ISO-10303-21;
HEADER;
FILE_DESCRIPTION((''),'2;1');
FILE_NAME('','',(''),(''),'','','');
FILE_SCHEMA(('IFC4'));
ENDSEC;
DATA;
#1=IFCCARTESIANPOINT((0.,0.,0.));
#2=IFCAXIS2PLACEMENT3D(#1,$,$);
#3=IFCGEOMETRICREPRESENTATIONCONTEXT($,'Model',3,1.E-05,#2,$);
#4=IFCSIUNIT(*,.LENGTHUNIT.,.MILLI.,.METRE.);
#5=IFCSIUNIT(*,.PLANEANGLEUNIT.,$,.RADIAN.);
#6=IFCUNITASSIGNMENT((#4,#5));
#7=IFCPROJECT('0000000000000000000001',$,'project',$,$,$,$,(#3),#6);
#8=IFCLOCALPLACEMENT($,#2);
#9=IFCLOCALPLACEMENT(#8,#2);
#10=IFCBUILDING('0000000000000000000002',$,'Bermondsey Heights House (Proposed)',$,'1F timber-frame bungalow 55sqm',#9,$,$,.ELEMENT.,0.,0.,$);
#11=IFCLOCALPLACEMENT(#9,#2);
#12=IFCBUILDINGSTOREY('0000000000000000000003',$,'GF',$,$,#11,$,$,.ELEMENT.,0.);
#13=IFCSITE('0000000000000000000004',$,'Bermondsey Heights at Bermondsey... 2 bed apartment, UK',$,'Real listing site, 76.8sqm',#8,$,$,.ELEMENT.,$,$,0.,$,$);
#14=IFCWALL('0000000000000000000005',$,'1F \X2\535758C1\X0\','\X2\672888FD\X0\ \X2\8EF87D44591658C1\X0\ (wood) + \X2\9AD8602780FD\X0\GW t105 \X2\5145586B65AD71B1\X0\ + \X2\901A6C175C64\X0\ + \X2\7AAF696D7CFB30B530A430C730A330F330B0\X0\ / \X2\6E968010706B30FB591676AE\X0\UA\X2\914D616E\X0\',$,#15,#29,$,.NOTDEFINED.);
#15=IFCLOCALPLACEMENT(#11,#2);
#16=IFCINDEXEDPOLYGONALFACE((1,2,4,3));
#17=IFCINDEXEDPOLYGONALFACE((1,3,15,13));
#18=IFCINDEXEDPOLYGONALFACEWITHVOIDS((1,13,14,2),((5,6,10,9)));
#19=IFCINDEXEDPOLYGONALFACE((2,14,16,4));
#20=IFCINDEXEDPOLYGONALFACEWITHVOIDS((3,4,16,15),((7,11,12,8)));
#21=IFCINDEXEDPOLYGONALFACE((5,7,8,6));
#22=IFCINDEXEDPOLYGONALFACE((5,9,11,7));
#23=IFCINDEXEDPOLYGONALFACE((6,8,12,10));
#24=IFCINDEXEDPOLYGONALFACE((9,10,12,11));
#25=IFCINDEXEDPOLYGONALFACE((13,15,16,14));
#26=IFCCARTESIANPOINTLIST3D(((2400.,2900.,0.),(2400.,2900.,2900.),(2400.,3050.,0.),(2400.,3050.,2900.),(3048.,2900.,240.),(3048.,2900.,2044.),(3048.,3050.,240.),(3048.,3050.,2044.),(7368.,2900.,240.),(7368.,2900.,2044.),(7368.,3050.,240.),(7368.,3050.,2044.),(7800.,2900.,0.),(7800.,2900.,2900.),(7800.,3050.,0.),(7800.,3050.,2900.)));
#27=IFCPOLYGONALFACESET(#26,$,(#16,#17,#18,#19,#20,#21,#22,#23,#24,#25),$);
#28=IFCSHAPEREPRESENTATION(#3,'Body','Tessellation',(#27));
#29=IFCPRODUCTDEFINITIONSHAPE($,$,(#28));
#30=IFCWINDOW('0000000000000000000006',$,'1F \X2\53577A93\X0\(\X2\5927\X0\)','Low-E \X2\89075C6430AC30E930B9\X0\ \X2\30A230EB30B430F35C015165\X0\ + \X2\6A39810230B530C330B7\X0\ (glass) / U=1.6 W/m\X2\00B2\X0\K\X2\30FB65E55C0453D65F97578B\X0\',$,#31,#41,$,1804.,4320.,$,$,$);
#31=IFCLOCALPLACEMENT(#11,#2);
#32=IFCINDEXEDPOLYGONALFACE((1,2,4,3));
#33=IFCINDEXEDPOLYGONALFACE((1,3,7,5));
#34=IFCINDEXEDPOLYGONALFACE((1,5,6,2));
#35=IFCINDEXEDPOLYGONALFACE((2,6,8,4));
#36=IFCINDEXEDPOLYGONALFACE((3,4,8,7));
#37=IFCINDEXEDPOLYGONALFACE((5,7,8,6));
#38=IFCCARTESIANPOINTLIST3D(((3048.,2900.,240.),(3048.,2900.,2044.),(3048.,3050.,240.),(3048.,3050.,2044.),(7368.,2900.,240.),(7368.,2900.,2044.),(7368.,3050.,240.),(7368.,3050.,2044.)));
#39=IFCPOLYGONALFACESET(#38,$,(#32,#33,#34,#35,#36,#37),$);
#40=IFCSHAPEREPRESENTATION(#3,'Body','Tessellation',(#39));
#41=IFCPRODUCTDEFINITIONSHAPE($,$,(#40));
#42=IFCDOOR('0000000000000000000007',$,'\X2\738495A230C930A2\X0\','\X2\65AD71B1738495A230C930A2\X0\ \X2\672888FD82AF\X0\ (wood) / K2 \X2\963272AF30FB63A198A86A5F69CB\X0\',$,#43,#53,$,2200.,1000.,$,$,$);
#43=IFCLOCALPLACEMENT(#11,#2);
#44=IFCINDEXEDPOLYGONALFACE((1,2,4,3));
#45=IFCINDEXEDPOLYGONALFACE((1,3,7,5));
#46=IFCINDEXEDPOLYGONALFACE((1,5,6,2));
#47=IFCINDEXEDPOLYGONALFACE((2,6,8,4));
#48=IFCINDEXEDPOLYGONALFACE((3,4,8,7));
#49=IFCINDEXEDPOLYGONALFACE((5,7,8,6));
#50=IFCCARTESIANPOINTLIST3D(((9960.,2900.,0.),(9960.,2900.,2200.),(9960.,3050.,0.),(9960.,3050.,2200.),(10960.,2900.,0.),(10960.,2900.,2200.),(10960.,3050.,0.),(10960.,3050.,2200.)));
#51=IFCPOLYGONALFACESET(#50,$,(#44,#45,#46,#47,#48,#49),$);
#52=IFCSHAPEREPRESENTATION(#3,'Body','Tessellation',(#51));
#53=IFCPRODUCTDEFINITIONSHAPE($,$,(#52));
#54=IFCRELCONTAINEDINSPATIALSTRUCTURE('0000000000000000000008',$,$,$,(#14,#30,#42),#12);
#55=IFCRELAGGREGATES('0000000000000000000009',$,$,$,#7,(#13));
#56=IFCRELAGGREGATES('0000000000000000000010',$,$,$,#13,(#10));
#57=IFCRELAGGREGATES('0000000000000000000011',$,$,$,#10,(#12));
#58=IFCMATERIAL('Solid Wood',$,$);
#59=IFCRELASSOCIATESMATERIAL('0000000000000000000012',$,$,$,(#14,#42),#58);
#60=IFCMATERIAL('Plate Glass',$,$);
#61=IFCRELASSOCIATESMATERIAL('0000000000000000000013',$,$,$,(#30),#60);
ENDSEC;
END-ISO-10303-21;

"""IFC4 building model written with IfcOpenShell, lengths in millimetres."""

from ifc_helpers import new_model, si_unit, frame, frame_2d, origin, place, context, project, spatial, rectangle, extrude, material, element, fill, save


model = new_model("IFC4")

# Units and contexts
model_context = context("Model", 3, precision=1e-05, world=origin())
ifc_project = project(units=[si_unit("LENGTHUNIT", "METRE", prefix="MILLI"), si_unit("PLANEANGLEUNIT", "RADIAN")], contexts=[model_context])

# Site, building, storey
site_placement = place(None, origin())
site = spatial("IfcSite", under=ifc_project, at=site_placement, Name="Bermondsey Heights at Bermondsey... 2 bed apartment, UK", ObjectType="Real listing site, 76.8sqm", CompositionType="ELEMENT", RefElevation=0.0)
building_placement = place(site_placement, origin())
building = spatial("IfcBuilding", under=site, at=building_placement, Name="Bermondsey Heights House (Proposed)", ObjectType="1F timber-frame bungalow 55sqm", CompositionType="ELEMENT", ElevationOfRefHeight=0.0, ElevationOfTerrain=0.0)
storey_placement = place(building_placement, origin())
storey = spatial("IfcBuildingStorey", under=building, at=storey_placement, Name="GF", CompositionType="ELEMENT", Elevation=0.0)

# Shared definitions
ifc_material_1 = material(Name="Solid Wood")

# Wall, openings, window, door
wall_1_placement = place(storey_placement, frame((1200.0, 1450.0, 0.0)))
wall_1 = element("IfcWall", 1, at=wall_1_placement, inside=storey, material=ifc_material_1, Name="1F 南壁", Description="木製 軸組外壁 (wood) + 高性能GW t105 充填断熱 + 通気層 + 窯業系サイディング / 準耐火・外皮UA配慮", PredefinedType="NOTDEFINED", context=model_context, shape_type="SweptSolid", body=[
    extrude(rectangle(XDim=5400.0, YDim=150.0, at=frame_2d((2700.0, 75.0))), frame((1200.0, 1450.0, 0.0)), (0.0, 0.0, 1.0), 2900.0),
])
opening_1_placement = place(storey_placement, frame((1524.0, 1450.0, 120.0)))
opening_1 = element("IfcOpeningElement", 2, at=opening_1_placement, cuts=wall_1, PredefinedType="NOTDEFINED", context=model_context, shape_type="SweptSolid", body=[
    extrude(rectangle(XDim=4320.0, YDim=150.0, at=frame_2d((2160.0, 75.0))), frame((1524.0, 1450.0, 120.0)), (0.0, 0.0, 1.0), 1804.0),
])
opening_2_placement = place(storey_placement, frame((4980.0, 1450.0, 0.0)))
opening_2 = element("IfcOpeningElement", 3, at=opening_2_placement, cuts=wall_1, PredefinedType="NOTDEFINED", context=model_context, shape_type="SweptSolid", body=[
    extrude(rectangle(XDim=1000.0, YDim=150.0, at=frame_2d((500.0, 75.0))), frame((4980.0, 1450.0, 0.0)), (0.0, 0.0, 1.0), 2200.0),
])
ifc_material_2 = material(Name="Plate Glass")
window_1_placement = place(storey_placement, frame((1524.0, 1450.0, 120.0)))
window_1 = element("IfcWindow", 4, at=window_1_placement, inside=storey, material=ifc_material_2, Name="1F 南窓(大)", Description="Low-E 複層ガラス アルゴン封入 + 樹脂サッシ (glass) / U=1.6 W/m²K・日射取得型", OverallHeight=1804.0, OverallWidth=4320.0, context=model_context, shape_type="SweptSolid", body=[
    extrude(rectangle(XDim=4320.0, YDim=150.0, at=frame_2d((2160.0, 75.0))), frame((1524.0, 1450.0, 120.0)), (0.0, 0.0, 1.0), 1804.0),
])
fill(opening_1, window_1)
door_placement = place(storey_placement, frame((4980.0, 1450.0, 0.0)))
door = element("IfcDoor", 5, at=door_placement, inside=storey, material=ifc_material_1, Name="玄関ドア", Description="断熱玄関ドア 木製芯 (wood) / K2 防犯・採風機構", OverallHeight=2200.0, OverallWidth=1000.0, context=model_context, shape_type="SweptSolid", body=[
    extrude(rectangle(XDim=1000.0, YDim=150.0, at=frame_2d((500.0, 75.0))), frame((4980.0, 1450.0, 0.0)), (0.0, 0.0, 1.0), 2200.0),
])
fill(opening_2, door)

save(model, "model.ifc")
